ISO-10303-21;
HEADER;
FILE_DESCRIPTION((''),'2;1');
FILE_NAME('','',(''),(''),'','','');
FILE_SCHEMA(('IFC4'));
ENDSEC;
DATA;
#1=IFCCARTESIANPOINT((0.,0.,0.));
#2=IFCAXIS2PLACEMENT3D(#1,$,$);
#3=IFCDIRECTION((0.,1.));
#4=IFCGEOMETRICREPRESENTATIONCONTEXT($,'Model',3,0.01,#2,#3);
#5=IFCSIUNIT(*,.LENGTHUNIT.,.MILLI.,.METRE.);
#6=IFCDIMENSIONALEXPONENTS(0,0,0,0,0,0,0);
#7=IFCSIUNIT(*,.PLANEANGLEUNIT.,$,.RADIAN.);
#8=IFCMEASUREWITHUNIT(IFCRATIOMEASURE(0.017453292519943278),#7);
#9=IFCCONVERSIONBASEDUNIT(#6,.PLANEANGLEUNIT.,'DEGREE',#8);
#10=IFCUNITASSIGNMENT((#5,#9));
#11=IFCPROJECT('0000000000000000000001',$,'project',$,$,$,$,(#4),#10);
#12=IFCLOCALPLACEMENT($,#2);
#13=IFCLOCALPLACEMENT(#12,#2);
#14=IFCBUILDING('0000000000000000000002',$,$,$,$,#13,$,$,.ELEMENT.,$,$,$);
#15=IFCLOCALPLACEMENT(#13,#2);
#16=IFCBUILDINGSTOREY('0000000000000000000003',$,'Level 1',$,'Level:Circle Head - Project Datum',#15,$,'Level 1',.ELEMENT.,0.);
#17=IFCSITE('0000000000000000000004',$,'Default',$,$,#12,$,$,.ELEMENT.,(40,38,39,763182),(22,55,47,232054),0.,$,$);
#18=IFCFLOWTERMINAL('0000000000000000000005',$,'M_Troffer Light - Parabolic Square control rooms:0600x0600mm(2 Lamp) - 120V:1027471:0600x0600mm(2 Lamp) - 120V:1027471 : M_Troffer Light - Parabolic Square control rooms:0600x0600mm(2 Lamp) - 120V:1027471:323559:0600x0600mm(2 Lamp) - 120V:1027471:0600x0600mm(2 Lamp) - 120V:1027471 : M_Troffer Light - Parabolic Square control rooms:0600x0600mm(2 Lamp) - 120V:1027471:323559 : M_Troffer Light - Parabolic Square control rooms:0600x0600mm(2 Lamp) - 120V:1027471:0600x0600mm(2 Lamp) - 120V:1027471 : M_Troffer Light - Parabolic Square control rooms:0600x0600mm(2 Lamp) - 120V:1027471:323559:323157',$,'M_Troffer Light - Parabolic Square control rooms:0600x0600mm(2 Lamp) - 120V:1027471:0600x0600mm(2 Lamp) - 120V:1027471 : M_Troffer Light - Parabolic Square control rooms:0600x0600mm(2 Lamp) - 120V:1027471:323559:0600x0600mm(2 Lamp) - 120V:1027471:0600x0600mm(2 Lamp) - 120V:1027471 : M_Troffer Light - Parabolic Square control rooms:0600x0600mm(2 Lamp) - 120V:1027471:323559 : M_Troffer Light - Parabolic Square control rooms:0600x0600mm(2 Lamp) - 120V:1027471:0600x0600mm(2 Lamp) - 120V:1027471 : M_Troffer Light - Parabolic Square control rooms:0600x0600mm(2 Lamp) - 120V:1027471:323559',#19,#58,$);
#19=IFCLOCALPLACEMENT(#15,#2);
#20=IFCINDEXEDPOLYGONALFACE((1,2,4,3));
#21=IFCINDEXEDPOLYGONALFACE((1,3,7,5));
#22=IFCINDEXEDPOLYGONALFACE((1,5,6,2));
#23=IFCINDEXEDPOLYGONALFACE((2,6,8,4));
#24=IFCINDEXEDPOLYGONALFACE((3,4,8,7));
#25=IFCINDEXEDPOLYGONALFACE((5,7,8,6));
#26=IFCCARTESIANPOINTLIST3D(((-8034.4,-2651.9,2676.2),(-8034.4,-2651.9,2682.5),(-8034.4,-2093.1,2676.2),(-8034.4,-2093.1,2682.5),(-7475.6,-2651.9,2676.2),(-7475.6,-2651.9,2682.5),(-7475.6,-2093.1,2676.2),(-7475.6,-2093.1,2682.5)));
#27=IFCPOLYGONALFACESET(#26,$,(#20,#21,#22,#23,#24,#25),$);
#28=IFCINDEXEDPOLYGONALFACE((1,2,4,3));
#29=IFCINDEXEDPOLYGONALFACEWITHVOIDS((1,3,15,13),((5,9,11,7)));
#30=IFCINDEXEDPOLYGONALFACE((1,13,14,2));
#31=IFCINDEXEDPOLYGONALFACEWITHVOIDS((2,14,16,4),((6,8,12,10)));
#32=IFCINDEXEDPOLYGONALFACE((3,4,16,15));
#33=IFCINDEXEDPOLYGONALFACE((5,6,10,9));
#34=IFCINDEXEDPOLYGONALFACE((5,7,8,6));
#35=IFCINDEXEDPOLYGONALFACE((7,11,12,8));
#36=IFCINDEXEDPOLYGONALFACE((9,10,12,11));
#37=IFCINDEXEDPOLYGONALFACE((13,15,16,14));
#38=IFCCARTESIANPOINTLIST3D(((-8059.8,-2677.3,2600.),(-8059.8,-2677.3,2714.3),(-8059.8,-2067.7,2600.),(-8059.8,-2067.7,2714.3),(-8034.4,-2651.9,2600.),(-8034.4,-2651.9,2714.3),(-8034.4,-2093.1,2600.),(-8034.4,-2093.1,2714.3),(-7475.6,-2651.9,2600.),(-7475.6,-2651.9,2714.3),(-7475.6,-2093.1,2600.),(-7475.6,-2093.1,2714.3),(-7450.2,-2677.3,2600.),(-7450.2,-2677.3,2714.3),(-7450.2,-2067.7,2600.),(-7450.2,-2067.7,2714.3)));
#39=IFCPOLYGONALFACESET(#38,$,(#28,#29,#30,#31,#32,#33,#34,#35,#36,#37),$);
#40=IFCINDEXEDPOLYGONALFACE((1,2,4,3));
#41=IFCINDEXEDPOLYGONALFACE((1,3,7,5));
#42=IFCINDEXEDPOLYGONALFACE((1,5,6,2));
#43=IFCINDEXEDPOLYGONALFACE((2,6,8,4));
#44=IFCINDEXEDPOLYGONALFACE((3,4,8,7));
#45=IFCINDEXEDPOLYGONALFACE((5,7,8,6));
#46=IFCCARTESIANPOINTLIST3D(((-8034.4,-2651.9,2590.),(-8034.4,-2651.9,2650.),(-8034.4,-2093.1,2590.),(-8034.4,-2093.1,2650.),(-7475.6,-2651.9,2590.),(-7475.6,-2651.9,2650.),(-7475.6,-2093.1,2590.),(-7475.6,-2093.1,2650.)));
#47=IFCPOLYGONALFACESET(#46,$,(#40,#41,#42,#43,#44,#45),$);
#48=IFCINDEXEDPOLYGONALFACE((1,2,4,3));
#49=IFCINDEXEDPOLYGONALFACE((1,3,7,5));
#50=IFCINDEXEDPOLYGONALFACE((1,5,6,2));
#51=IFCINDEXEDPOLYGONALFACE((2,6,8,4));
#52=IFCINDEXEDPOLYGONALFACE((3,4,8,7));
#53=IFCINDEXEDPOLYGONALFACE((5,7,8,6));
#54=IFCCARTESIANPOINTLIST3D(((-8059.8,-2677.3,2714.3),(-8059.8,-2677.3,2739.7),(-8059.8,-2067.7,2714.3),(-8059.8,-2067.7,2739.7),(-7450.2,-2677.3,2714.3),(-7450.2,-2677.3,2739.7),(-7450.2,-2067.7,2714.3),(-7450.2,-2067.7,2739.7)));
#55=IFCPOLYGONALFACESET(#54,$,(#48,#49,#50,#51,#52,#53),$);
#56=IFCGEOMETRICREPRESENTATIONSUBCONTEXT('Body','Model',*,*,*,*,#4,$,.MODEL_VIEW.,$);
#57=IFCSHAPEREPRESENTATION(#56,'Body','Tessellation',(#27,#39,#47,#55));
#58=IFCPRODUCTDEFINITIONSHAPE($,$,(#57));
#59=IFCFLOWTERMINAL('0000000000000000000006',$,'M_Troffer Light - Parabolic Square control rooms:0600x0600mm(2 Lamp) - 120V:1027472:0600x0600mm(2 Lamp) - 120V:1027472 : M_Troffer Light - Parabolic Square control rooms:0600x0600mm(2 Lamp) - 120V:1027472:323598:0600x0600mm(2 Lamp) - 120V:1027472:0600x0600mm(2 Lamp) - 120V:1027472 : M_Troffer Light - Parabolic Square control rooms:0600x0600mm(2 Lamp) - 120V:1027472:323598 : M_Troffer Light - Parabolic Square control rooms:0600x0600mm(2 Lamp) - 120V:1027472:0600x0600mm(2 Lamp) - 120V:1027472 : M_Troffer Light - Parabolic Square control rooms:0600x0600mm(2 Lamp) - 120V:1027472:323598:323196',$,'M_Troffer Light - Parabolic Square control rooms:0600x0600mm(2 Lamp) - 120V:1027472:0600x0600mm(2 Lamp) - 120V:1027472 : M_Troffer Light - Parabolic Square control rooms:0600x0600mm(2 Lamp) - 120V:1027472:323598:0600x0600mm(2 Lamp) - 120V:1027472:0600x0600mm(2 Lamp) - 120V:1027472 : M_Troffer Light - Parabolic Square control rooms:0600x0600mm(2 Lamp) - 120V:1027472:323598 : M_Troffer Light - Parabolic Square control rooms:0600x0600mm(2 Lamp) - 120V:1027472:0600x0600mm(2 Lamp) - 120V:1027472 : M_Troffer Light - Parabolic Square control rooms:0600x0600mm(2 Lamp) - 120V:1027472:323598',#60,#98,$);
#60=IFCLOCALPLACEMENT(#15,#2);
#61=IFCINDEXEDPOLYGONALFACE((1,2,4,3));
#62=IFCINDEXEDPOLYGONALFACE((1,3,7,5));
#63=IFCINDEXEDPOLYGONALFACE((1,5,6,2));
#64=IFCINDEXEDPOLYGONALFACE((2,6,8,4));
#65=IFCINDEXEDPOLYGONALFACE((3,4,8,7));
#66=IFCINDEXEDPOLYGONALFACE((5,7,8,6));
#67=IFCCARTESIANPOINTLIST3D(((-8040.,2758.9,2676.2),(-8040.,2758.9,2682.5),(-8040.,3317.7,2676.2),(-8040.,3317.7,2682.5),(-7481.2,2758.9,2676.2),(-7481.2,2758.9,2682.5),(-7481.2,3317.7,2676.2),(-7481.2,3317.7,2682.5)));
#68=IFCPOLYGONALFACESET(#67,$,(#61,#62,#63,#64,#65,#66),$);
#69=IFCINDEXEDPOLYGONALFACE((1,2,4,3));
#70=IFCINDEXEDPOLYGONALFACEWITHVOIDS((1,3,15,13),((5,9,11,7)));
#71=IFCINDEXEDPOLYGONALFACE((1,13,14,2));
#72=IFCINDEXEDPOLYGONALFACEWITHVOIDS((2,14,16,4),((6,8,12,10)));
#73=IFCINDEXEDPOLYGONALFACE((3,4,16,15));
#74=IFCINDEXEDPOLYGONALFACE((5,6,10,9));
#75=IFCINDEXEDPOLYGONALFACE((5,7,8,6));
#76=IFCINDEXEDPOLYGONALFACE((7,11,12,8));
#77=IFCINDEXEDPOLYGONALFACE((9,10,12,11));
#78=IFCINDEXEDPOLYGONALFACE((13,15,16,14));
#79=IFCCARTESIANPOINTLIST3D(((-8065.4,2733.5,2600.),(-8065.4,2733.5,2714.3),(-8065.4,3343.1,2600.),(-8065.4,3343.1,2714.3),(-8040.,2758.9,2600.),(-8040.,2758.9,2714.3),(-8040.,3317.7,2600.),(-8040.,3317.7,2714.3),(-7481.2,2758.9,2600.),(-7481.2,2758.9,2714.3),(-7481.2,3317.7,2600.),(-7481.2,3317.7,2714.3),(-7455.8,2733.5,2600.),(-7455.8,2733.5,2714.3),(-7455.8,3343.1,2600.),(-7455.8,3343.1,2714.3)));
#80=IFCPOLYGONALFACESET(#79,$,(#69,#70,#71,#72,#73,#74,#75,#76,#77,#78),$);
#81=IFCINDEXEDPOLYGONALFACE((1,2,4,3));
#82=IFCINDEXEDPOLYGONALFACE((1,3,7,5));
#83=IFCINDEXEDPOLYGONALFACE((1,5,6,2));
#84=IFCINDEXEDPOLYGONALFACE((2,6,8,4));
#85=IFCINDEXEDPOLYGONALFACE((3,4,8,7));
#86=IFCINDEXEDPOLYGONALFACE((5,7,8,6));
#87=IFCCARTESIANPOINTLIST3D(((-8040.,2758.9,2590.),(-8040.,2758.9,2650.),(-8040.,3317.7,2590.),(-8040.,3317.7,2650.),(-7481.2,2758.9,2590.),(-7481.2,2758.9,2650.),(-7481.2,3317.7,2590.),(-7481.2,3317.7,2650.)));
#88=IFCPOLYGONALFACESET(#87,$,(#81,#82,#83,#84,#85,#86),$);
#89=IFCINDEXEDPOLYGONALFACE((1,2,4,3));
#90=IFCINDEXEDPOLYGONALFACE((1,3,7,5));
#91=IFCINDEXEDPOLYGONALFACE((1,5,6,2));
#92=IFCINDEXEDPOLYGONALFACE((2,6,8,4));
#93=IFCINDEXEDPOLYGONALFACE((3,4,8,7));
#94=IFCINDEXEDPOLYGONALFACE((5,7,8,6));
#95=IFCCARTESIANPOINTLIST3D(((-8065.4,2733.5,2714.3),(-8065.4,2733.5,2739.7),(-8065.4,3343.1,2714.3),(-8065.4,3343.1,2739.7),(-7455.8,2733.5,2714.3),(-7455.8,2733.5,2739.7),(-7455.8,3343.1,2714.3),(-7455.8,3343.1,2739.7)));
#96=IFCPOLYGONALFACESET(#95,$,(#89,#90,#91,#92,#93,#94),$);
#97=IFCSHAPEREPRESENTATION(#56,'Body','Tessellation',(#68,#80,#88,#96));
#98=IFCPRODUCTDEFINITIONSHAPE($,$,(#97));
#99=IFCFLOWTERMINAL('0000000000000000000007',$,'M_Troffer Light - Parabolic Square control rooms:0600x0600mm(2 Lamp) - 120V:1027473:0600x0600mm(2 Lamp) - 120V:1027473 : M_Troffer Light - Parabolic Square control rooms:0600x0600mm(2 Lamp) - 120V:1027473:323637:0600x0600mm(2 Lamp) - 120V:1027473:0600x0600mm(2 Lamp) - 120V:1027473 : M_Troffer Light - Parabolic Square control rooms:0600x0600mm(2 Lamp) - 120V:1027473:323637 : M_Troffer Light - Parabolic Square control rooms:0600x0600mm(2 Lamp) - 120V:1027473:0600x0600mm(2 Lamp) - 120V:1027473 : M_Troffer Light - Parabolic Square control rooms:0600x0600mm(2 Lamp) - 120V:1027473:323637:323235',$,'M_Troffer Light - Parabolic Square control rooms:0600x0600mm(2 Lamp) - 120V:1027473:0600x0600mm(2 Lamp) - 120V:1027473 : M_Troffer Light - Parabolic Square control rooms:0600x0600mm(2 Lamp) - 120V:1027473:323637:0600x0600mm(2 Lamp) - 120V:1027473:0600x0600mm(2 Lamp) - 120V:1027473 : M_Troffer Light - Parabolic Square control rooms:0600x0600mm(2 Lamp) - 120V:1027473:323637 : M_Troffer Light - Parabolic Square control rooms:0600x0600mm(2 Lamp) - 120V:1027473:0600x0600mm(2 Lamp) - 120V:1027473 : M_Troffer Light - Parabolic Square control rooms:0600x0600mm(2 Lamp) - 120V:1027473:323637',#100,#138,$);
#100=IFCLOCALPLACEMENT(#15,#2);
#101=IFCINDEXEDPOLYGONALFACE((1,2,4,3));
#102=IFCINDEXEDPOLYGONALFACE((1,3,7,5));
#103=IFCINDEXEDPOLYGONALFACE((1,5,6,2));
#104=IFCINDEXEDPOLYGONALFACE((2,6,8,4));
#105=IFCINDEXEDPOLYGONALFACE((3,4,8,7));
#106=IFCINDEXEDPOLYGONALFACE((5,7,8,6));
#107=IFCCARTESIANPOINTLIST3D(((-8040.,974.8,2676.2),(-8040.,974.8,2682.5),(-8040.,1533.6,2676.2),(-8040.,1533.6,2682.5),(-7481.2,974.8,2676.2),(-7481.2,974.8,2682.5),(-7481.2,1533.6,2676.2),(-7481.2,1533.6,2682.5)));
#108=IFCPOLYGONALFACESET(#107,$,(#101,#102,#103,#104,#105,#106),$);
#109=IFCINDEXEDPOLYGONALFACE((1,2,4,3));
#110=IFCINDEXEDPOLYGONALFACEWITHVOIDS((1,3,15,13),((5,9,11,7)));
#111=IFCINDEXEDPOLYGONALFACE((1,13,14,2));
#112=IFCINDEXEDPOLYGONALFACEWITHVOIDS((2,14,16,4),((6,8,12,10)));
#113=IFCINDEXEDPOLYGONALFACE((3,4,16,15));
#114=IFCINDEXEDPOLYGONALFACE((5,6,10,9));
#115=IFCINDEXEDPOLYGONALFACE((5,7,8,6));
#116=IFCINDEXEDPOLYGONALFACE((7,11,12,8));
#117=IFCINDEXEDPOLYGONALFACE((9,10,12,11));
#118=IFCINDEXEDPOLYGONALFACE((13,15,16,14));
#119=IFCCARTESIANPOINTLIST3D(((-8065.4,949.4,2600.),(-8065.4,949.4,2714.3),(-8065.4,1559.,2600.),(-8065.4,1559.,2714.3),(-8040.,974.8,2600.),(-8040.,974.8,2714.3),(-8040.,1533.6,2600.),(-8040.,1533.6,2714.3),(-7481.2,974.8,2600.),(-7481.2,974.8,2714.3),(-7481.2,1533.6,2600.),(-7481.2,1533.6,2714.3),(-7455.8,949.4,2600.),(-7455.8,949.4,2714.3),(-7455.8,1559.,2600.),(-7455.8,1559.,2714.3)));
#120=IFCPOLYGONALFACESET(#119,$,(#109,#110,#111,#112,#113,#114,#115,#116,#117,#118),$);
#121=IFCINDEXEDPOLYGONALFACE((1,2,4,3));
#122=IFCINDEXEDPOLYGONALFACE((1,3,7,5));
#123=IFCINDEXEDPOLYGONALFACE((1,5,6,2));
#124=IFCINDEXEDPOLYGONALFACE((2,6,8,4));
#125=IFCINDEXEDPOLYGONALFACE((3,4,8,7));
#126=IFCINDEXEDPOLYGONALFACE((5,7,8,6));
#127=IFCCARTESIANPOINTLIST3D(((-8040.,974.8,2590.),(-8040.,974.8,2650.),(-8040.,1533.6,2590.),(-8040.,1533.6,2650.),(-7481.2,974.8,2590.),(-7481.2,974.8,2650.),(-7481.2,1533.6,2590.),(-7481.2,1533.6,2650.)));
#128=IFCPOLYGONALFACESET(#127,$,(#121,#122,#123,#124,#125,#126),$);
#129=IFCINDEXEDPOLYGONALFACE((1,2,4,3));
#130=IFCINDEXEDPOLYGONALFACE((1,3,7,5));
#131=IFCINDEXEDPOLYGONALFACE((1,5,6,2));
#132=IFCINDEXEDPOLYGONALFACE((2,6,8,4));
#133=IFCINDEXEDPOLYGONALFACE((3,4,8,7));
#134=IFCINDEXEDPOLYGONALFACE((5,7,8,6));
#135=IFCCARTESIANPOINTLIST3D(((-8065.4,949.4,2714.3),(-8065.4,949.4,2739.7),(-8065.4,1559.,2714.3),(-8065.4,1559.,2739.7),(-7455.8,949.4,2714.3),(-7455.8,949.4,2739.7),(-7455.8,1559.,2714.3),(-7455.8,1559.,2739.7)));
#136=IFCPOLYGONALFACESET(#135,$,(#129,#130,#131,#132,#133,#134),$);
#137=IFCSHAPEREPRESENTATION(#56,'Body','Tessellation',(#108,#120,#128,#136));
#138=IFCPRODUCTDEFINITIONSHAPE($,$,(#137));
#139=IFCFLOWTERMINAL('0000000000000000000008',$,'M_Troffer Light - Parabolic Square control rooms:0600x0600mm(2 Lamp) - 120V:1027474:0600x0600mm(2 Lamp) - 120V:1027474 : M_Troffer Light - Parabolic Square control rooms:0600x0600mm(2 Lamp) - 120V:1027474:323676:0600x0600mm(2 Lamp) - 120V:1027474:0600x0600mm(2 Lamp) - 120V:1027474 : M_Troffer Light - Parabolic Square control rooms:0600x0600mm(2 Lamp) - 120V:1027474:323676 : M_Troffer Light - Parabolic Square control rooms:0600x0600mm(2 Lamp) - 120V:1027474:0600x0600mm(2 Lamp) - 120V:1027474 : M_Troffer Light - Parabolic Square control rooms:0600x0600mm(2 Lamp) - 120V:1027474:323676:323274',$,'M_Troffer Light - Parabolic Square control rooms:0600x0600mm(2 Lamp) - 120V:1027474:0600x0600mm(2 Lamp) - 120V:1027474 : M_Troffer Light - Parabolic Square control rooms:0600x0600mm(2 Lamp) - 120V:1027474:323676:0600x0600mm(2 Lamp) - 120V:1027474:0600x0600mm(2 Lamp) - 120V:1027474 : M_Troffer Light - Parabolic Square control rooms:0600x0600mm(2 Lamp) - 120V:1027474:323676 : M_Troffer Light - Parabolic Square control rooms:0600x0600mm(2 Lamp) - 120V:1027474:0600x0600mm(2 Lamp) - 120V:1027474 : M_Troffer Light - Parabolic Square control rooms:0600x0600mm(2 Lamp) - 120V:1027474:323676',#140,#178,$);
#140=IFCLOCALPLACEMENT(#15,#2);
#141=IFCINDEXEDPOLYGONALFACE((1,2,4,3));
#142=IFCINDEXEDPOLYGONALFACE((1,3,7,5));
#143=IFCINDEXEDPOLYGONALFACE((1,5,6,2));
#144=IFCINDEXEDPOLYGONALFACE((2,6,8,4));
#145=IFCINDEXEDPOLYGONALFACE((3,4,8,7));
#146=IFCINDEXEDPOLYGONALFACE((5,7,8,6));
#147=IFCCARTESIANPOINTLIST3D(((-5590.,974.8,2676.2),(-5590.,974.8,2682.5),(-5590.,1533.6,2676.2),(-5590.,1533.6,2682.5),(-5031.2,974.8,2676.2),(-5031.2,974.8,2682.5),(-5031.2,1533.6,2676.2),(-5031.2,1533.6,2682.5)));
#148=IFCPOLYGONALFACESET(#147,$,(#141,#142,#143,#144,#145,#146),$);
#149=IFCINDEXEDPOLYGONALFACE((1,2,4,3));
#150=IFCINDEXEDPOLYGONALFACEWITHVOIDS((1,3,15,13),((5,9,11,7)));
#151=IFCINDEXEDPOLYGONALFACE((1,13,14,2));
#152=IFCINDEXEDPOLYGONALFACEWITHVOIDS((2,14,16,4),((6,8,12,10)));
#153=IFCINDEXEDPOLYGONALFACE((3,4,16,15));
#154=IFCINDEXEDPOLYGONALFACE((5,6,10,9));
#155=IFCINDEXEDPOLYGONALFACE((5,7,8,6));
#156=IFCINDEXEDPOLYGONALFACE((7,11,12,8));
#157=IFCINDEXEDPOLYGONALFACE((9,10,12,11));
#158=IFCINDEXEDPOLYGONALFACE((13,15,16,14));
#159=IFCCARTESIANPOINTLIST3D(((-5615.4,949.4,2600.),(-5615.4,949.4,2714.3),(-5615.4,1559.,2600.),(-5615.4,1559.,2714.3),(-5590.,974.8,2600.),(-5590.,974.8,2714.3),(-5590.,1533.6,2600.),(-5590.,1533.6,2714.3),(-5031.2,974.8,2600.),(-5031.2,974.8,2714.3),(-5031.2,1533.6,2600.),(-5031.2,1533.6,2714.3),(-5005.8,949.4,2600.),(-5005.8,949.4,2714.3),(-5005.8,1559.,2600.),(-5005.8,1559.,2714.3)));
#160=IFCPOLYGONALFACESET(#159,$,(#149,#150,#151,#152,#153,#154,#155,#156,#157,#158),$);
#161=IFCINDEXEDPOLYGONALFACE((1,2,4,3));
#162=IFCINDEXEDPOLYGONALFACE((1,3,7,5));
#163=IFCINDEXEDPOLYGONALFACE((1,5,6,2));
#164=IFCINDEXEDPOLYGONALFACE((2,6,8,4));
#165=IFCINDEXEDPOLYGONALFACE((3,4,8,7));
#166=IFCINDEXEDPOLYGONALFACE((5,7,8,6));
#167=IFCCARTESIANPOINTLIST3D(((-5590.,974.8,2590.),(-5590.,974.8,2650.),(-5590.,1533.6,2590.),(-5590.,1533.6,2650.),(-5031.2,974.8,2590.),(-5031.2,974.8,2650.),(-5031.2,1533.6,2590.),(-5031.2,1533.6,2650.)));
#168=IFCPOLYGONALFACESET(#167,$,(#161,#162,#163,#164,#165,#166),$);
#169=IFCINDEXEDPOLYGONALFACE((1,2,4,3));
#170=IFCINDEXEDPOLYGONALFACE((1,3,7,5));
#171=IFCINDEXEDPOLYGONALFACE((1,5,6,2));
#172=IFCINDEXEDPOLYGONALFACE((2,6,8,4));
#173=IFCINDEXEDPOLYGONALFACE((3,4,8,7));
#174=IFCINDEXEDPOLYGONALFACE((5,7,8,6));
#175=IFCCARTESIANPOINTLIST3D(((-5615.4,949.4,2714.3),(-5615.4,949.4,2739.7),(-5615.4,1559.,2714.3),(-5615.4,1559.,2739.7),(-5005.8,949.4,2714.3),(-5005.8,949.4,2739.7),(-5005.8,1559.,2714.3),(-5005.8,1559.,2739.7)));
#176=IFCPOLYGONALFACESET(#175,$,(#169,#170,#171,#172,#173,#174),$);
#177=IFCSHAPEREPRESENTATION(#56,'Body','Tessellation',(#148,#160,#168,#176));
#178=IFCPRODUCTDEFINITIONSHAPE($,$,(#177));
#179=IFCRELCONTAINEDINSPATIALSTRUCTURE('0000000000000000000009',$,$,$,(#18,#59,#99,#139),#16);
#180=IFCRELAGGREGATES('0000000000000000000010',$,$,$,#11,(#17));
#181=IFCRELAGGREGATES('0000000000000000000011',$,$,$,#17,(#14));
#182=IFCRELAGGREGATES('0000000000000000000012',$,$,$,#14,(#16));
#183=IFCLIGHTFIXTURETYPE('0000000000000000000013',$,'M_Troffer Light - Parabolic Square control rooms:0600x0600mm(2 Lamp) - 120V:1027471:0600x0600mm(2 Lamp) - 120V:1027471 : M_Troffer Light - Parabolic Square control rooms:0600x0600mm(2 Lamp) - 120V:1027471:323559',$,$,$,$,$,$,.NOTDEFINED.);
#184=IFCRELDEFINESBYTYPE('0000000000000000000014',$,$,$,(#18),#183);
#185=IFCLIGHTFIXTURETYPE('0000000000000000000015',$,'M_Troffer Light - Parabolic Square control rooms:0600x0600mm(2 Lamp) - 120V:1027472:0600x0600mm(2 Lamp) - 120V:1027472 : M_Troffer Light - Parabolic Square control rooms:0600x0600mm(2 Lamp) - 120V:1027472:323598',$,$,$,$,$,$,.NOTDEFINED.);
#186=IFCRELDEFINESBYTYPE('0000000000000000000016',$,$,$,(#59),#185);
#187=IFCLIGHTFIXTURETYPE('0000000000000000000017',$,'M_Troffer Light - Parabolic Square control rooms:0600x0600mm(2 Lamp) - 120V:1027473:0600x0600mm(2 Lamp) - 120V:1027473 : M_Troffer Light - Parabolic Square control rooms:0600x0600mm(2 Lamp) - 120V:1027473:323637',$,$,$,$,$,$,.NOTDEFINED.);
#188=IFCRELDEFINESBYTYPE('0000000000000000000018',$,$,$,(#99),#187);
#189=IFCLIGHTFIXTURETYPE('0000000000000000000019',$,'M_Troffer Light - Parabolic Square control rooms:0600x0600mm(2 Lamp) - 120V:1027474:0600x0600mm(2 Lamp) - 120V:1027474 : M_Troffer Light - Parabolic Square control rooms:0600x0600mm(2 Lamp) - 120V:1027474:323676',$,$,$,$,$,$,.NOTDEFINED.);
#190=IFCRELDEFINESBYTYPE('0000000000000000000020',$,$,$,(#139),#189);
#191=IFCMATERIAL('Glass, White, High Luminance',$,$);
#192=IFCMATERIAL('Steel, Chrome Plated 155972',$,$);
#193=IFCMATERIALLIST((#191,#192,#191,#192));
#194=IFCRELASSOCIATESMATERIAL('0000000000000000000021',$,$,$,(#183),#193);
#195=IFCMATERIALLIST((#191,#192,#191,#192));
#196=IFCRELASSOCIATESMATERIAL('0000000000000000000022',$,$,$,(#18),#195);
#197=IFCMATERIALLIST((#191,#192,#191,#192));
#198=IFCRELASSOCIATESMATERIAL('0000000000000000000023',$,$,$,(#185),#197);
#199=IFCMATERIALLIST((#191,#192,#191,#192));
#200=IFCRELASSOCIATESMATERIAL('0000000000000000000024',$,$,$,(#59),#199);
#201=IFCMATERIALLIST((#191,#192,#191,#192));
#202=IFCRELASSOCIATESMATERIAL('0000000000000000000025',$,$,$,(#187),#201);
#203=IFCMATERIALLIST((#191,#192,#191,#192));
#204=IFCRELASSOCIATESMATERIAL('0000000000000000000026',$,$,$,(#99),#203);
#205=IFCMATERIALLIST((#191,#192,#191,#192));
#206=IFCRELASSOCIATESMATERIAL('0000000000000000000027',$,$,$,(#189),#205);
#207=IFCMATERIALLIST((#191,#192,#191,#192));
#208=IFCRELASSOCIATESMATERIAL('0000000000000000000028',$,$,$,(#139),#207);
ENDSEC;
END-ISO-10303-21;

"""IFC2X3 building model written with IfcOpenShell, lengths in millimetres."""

from ifc_helpers import new_model, entity, si_unit, converted_unit, direction, frame, frame_2d, origin, origin_2d_with_axis, place, context, subcontext, project, spatial, polyline, rectangle, outline, extrude, source, transform, mapped, material, material_list, type_object, type_shapes, element, save


model = new_model("IFC2X3")

# Units and contexts
model_context = context("Model", 3, precision=0.01, world=origin(), true_north=direction((0.0, 1.0)))
body_context = subcontext(model_context, "Body", "Model", "MODEL_VIEW")
ifc_project = project(units=[si_unit("LENGTHUNIT", "METRE", prefix="MILLI"), converted_unit("PLANEANGLEUNIT", "DEGREE", entity("IfcRatioMeasure", 0.017453292519943278), si_unit("PLANEANGLEUNIT", "RADIAN"), dimensions=[0, 0, 0, 0, 0, 0, 0])], contexts=[model_context])

# Site, building, storey
site_placement = place(None, origin())
site = spatial("IfcSite", under=ifc_project, at=site_placement, Name="Default", CompositionType="ELEMENT", RefLatitude=(40, 38, 39, 763182), RefLongitude=(22, 55, 47, 232054), RefElevation=0.0)
building_placement = place(site_placement, origin())
building = spatial("IfcBuilding", under=site, at=building_placement, CompositionType="ELEMENT")
storey_placement = place(building_placement, origin())
storey = spatial("IfcBuildingStorey", under=building, at=storey_placement, Name="Level 1", ObjectType="Level:Circle Head - Project Datum", LongName="Level 1", CompositionType="ELEMENT", Elevation=0.0)

# Flow terminals
ifc_material_1 = material(Name="Glass, White, High Luminance")
ifc_material_2 = material(Name="Steel, Chrome Plated 155972")
ifc_material_list_1 = material_list([ifc_material_1, ifc_material_2, ifc_material_1, ifc_material_2])
ifc_material_list_2 = material_list([ifc_material_1, ifc_material_2, ifc_material_1, ifc_material_2])
light_fixture_type_1 = type_object("IfcLightFixtureType", Name="M_Troffer Light - Parabolic Square control rooms:0600x0600mm(2 Lamp) - 120V:1027471:0600x0600mm(2 Lamp) - 120V:1027471 : M_Troffer Light - Parabolic Square control rooms:0600x0600mm(2 Lamp) - 120V:1027471:323559", PredefinedType="NOTDEFINED", material=ifc_material_list_2)
shared_shape_1 = source(origin(), body_context, "Body", "SweptSolid", [
    extrude(rectangle(XDim=558.8, YDim=558.8, at=frame_2d((0.0, 0.0), x_axis=(1.0, 0.0))), frame((-7755.0, -2372.5, 2676.2), z_axis=(0.0, 0.0, 1.0), x_axis=(0.0, 1.0, 0.0)), (0.0, 0.0, 1.0), 6.4),
    extrude(outline(polyline([(-304.8, -304.8), (304.8, -304.8), (304.8, 304.8), (-304.8, 304.8), (-304.8, -304.8)]), holes=[polyline([(279.4, 279.4), (279.4, -279.4), (-279.4, -279.4), (-279.4, 279.4), (279.4, 279.4)])]), frame((-7755.0, -2372.5, 2600.0), z_axis=(0.0, 0.0, 1.0), x_axis=(0.0, -1.0, 0.0)), (0.0, 0.0, 1.0), 114.3),
    extrude(rectangle(XDim=558.8, YDim=558.8, at=frame_2d((0.0, 0.0), x_axis=(1.0, 0.0))), frame((-7755.0, -2372.5, 2590.0), z_axis=(0.0, 0.0, 1.0), x_axis=(0.0, 1.0, 0.0)), (0.0, 0.0, 1.0), 60.0),
    extrude(rectangle(XDim=609.6, YDim=609.6, at=frame_2d((0.0, 0.0), x_axis=(1.0, 0.0))), frame((-7755.0, -2372.5, 2714.3), z_axis=(0.0, 0.0, 1.0), x_axis=(0.0, 1.0, 0.0)), (0.0, 0.0, 1.0), 25.4),
])
type_shapes(light_fixture_type_1, [shared_shape_1])
flow_terminal_1_placement = place(storey_placement, origin())
element("IfcFlowTerminal", 1, at=flow_terminal_1_placement, inside=storey, type_object=light_fixture_type_1, material=ifc_material_list_1, Name="M_Troffer Light - Parabolic Square control rooms:0600x0600mm(2 Lamp) - 120V:1027471:0600x0600mm(2 Lamp) - 120V:1027471 : M_Troffer Light - Parabolic Square control rooms:0600x0600mm(2 Lamp) - 120V:1027471:323559:0600x0600mm(2 Lamp) - 120V:1027471:0600x0600mm(2 Lamp) - 120V:1027471 : M_Troffer Light - Parabolic Square control rooms:0600x0600mm(2 Lamp) - 120V:1027471:323559 : M_Troffer Light - Parabolic Square control rooms:0600x0600mm(2 Lamp) - 120V:1027471:0600x0600mm(2 Lamp) - 120V:1027471 : M_Troffer Light - Parabolic Square control rooms:0600x0600mm(2 Lamp) - 120V:1027471:323559:323157", ObjectType="M_Troffer Light - Parabolic Square control rooms:0600x0600mm(2 Lamp) - 120V:1027471:0600x0600mm(2 Lamp) - 120V:1027471 : M_Troffer Light - Parabolic Square control rooms:0600x0600mm(2 Lamp) - 120V:1027471:323559:0600x0600mm(2 Lamp) - 120V:1027471:0600x0600mm(2 Lamp) - 120V:1027471 : M_Troffer Light - Parabolic Square control rooms:0600x0600mm(2 Lamp) - 120V:1027471:323559 : M_Troffer Light - Parabolic Square control rooms:0600x0600mm(2 Lamp) - 120V:1027471:0600x0600mm(2 Lamp) - 120V:1027471 : M_Troffer Light - Parabolic Square control rooms:0600x0600mm(2 Lamp) - 120V:1027471:323559", context=body_context, shape_type="MappedRepresentation", body=[
    mapped(shared_shape_1, transform((0.0, 0.0, 0.0), scale=1.0)),
])
ifc_material_list_3 = material_list([ifc_material_1, ifc_material_2, ifc_material_1, ifc_material_2])
ifc_material_list_4 = material_list([ifc_material_1, ifc_material_2, ifc_material_1, ifc_material_2])
light_fixture_type_2 = type_object("IfcLightFixtureType", Name="M_Troffer Light - Parabolic Square control rooms:0600x0600mm(2 Lamp) - 120V:1027472:0600x0600mm(2 Lamp) - 120V:1027472 : M_Troffer Light - Parabolic Square control rooms:0600x0600mm(2 Lamp) - 120V:1027472:323598", PredefinedType="NOTDEFINED", material=ifc_material_list_4)
shared_shape_2 = source(origin(), body_context, "Body", "SweptSolid", [
    extrude(rectangle(XDim=558.8, YDim=558.8, at=frame_2d((0.0, 0.0), x_axis=(1.0, 0.0))), frame((-7760.6, 3038.3, 2676.2), z_axis=(0.0, 0.0, 1.0), x_axis=(0.0, 1.0, 0.0)), (0.0, 0.0, 1.0), 6.4),
    extrude(outline(polyline([(-304.8, -304.8), (304.8, -304.8), (304.8, 304.8), (-304.8, 304.8), (-304.8, -304.8)]), holes=[polyline([(279.4, 279.4), (279.4, -279.4), (-279.4, -279.4), (-279.4, 279.4), (279.4, 279.4)])]), frame((-7760.6, 3038.3, 2600.0), z_axis=(0.0, 0.0, 1.0), x_axis=(0.0, -1.0, 0.0)), (0.0, 0.0, 1.0), 114.3),
    extrude(rectangle(XDim=558.8, YDim=558.8, at=frame_2d((0.0, 0.0), x_axis=(1.0, 0.0))), frame((-7760.6, 3038.3, 2590.0), z_axis=(0.0, 0.0, 1.0), x_axis=(0.0, 1.0, 0.0)), (0.0, 0.0, 1.0), 60.0),
    extrude(rectangle(XDim=609.6, YDim=609.6, at=frame_2d((0.0, 0.0), x_axis=(1.0, 0.0))), frame((-7760.6, 3038.3, 2714.3), z_axis=(0.0, 0.0, 1.0), x_axis=(0.0, 1.0, 0.0)), (0.0, 0.0, 1.0), 25.4),
])
type_shapes(light_fixture_type_2, [shared_shape_2])
flow_terminal_2_placement = place(storey_placement, origin())
element("IfcFlowTerminal", 2, at=flow_terminal_2_placement, inside=storey, type_object=light_fixture_type_2, material=ifc_material_list_3, Name="M_Troffer Light - Parabolic Square control rooms:0600x0600mm(2 Lamp) - 120V:1027472:0600x0600mm(2 Lamp) - 120V:1027472 : M_Troffer Light - Parabolic Square control rooms:0600x0600mm(2 Lamp) - 120V:1027472:323598:0600x0600mm(2 Lamp) - 120V:1027472:0600x0600mm(2 Lamp) - 120V:1027472 : M_Troffer Light - Parabolic Square control rooms:0600x0600mm(2 Lamp) - 120V:1027472:323598 : M_Troffer Light - Parabolic Square control rooms:0600x0600mm(2 Lamp) - 120V:1027472:0600x0600mm(2 Lamp) - 120V:1027472 : M_Troffer Light - Parabolic Square control rooms:0600x0600mm(2 Lamp) - 120V:1027472:323598:323196", ObjectType="M_Troffer Light - Parabolic Square control rooms:0600x0600mm(2 Lamp) - 120V:1027472:0600x0600mm(2 Lamp) - 120V:1027472 : M_Troffer Light - Parabolic Square control rooms:0600x0600mm(2 Lamp) - 120V:1027472:323598:0600x0600mm(2 Lamp) - 120V:1027472:0600x0600mm(2 Lamp) - 120V:1027472 : M_Troffer Light - Parabolic Square control rooms:0600x0600mm(2 Lamp) - 120V:1027472:323598 : M_Troffer Light - Parabolic Square control rooms:0600x0600mm(2 Lamp) - 120V:1027472:0600x0600mm(2 Lamp) - 120V:1027472 : M_Troffer Light - Parabolic Square control rooms:0600x0600mm(2 Lamp) - 120V:1027472:323598", context=body_context, shape_type="MappedRepresentation", body=[
    mapped(shared_shape_2, transform((0.0, 0.0, 0.0), scale=1.0)),
])
ifc_material_list_5 = material_list([ifc_material_1, ifc_material_2, ifc_material_1, ifc_material_2])
ifc_material_list_6 = material_list([ifc_material_1, ifc_material_2, ifc_material_1, ifc_material_2])
light_fixture_type_3 = type_object("IfcLightFixtureType", Name="M_Troffer Light - Parabolic Square control rooms:0600x0600mm(2 Lamp) - 120V:1027473:0600x0600mm(2 Lamp) - 120V:1027473 : M_Troffer Light - Parabolic Square control rooms:0600x0600mm(2 Lamp) - 120V:1027473:323637", PredefinedType="NOTDEFINED", material=ifc_material_list_6)
shared_shape_3 = source(origin(), body_context, "Body", "SweptSolid", [
    extrude(rectangle(XDim=558.8, YDim=558.8, at=frame_2d((0.0, 0.0), x_axis=(1.0, 0.0))), frame((-7760.6, 1254.2, 2676.2), z_axis=(0.0, 0.0, 1.0), x_axis=(0.0, 1.0, 0.0)), (0.0, 0.0, 1.0), 6.4),
    extrude(outline(polyline([(-304.8, -304.8), (304.8, -304.8), (304.8, 304.8), (-304.8, 304.8), (-304.8, -304.8)]), holes=[polyline([(279.4, 279.4), (279.4, -279.4), (-279.4, -279.4), (-279.4, 279.4), (279.4, 279.4)])]), frame((-7760.6, 1254.2, 2600.0), z_axis=(0.0, 0.0, 1.0), x_axis=(0.0, -1.0, 0.0)), (0.0, 0.0, 1.0), 114.3),
    extrude(rectangle(XDim=558.8, YDim=558.8, at=frame_2d((0.0, 0.0), x_axis=(1.0, 0.0))), frame((-7760.6, 1254.2, 2590.0), z_axis=(0.0, 0.0, 1.0), x_axis=(0.0, 1.0, 0.0)), (0.0, 0.0, 1.0), 60.0),
    extrude(rectangle(XDim=609.6, YDim=609.6, at=origin_2d_with_axis()), frame((-7760.6, 1254.2, 2714.3), z_axis=(0.0, 0.0, 1.0), x_axis=(0.0, 1.0, 0.0)), (0.0, 0.0, 1.0), 25.4),
])
type_shapes(light_fixture_type_3, [shared_shape_3])
flow_terminal_3_placement = place(storey_placement, origin())
element("IfcFlowTerminal", 3, at=flow_terminal_3_placement, inside=storey, type_object=light_fixture_type_3, material=ifc_material_list_5, Name="M_Troffer Light - Parabolic Square control rooms:0600x0600mm(2 Lamp) - 120V:1027473:0600x0600mm(2 Lamp) - 120V:1027473 : M_Troffer Light - Parabolic Square control rooms:0600x0600mm(2 Lamp) - 120V:1027473:323637:0600x0600mm(2 Lamp) - 120V:1027473:0600x0600mm(2 Lamp) - 120V:1027473 : M_Troffer Light - Parabolic Square control rooms:0600x0600mm(2 Lamp) - 120V:1027473:323637 : M_Troffer Light - Parabolic Square control rooms:0600x0600mm(2 Lamp) - 120V:1027473:0600x0600mm(2 Lamp) - 120V:1027473 : M_Troffer Light - Parabolic Square control rooms:0600x0600mm(2 Lamp) - 120V:1027473:323637:323235", ObjectType="M_Troffer Light - Parabolic Square control rooms:0600x0600mm(2 Lamp) - 120V:1027473:0600x0600mm(2 Lamp) - 120V:1027473 : M_Troffer Light - Parabolic Square control rooms:0600x0600mm(2 Lamp) - 120V:1027473:323637:0600x0600mm(2 Lamp) - 120V:1027473:0600x0600mm(2 Lamp) - 120V:1027473 : M_Troffer Light - Parabolic Square control rooms:0600x0600mm(2 Lamp) - 120V:1027473:323637 : M_Troffer Light - Parabolic Square control rooms:0600x0600mm(2 Lamp) - 120V:1027473:0600x0600mm(2 Lamp) - 120V:1027473 : M_Troffer Light - Parabolic Square control rooms:0600x0600mm(2 Lamp) - 120V:1027473:323637", context=body_context, shape_type="MappedRepresentation", body=[
    mapped(shared_shape_3, transform((0.0, 0.0, 0.0), scale=1.0)),
])
ifc_material_list_7 = material_list([ifc_material_1, ifc_material_2, ifc_material_1, ifc_material_2])
ifc_material_list_8 = material_list([ifc_material_1, ifc_material_2, ifc_material_1, ifc_material_2])
light_fixture_type_4 = type_object("IfcLightFixtureType", Name="M_Troffer Light - Parabolic Square control rooms:0600x0600mm(2 Lamp) - 120V:1027474:0600x0600mm(2 Lamp) - 120V:1027474 : M_Troffer Light - Parabolic Square control rooms:0600x0600mm(2 Lamp) - 120V:1027474:323676", PredefinedType="NOTDEFINED", material=ifc_material_list_8)
shared_shape_4 = source(origin(), body_context, "Body", "SweptSolid", [
    extrude(rectangle(XDim=558.8, YDim=558.8, at=frame_2d((0.0, 0.0), x_axis=(1.0, 0.0))), frame((-5310.6, 1254.2, 2676.2), z_axis=(0.0, 0.0, 1.0), x_axis=(0.0, 1.0, 0.0)), (0.0, 0.0, 1.0), 6.4),
    extrude(outline(polyline([(-304.8, -304.8), (304.8, -304.8), (304.8, 304.8), (-304.8, 304.8), (-304.8, -304.8)]), holes=[polyline([(279.4, 279.4), (279.4, -279.4), (-279.4, -279.4), (-279.4, 279.4), (279.4, 279.4)])]), frame((-5310.6, 1254.2, 2600.0), z_axis=(0.0, 0.0, 1.0), x_axis=(0.0, -1.0, 0.0)), (0.0, 0.0, 1.0), 114.3),
    extrude(rectangle(XDim=558.8, YDim=558.8, at=frame_2d((0.0, 0.0), x_axis=(1.0, 0.0))), frame((-5310.6, 1254.2, 2590.0), z_axis=(0.0, 0.0, 1.0), x_axis=(0.0, 1.0, 0.0)), (0.0, 0.0, 1.0), 60.0),
    extrude(rectangle(XDim=609.6, YDim=609.6, at=frame_2d((0.0, 0.0), x_axis=(1.0, 0.0))), frame((-5310.6, 1254.2, 2714.3), z_axis=(0.0, 0.0, 1.0), x_axis=(0.0, 1.0, 0.0)), (0.0, 0.0, 1.0), 25.4),
])
type_shapes(light_fixture_type_4, [shared_shape_4])
flow_terminal_4_placement = place(storey_placement, origin())
element("IfcFlowTerminal", 4, at=flow_terminal_4_placement, inside=storey, type_object=light_fixture_type_4, material=ifc_material_list_7, Name="M_Troffer Light - Parabolic Square control rooms:0600x0600mm(2 Lamp) - 120V:1027474:0600x0600mm(2 Lamp) - 120V:1027474 : M_Troffer Light - Parabolic Square control rooms:0600x0600mm(2 Lamp) - 120V:1027474:323676:0600x0600mm(2 Lamp) - 120V:1027474:0600x0600mm(2 Lamp) - 120V:1027474 : M_Troffer Light - Parabolic Square control rooms:0600x0600mm(2 Lamp) - 120V:1027474:323676 : M_Troffer Light - Parabolic Square control rooms:0600x0600mm(2 Lamp) - 120V:1027474:0600x0600mm(2 Lamp) - 120V:1027474 : M_Troffer Light - Parabolic Square control rooms:0600x0600mm(2 Lamp) - 120V:1027474:323676:323274", ObjectType="M_Troffer Light - Parabolic Square control rooms:0600x0600mm(2 Lamp) - 120V:1027474:0600x0600mm(2 Lamp) - 120V:1027474 : M_Troffer Light - Parabolic Square control rooms:0600x0600mm(2 Lamp) - 120V:1027474:323676:0600x0600mm(2 Lamp) - 120V:1027474:0600x0600mm(2 Lamp) - 120V:1027474 : M_Troffer Light - Parabolic Square control rooms:0600x0600mm(2 Lamp) - 120V:1027474:323676 : M_Troffer Light - Parabolic Square control rooms:0600x0600mm(2 Lamp) - 120V:1027474:0600x0600mm(2 Lamp) - 120V:1027474 : M_Troffer Light - Parabolic Square control rooms:0600x0600mm(2 Lamp) - 120V:1027474:323676", context=body_context, shape_type="MappedRepresentation", body=[
    mapped(shared_shape_4, transform((0.0, 0.0, 0.0), scale=1.0)),
])

save(model, "model.ifc")
